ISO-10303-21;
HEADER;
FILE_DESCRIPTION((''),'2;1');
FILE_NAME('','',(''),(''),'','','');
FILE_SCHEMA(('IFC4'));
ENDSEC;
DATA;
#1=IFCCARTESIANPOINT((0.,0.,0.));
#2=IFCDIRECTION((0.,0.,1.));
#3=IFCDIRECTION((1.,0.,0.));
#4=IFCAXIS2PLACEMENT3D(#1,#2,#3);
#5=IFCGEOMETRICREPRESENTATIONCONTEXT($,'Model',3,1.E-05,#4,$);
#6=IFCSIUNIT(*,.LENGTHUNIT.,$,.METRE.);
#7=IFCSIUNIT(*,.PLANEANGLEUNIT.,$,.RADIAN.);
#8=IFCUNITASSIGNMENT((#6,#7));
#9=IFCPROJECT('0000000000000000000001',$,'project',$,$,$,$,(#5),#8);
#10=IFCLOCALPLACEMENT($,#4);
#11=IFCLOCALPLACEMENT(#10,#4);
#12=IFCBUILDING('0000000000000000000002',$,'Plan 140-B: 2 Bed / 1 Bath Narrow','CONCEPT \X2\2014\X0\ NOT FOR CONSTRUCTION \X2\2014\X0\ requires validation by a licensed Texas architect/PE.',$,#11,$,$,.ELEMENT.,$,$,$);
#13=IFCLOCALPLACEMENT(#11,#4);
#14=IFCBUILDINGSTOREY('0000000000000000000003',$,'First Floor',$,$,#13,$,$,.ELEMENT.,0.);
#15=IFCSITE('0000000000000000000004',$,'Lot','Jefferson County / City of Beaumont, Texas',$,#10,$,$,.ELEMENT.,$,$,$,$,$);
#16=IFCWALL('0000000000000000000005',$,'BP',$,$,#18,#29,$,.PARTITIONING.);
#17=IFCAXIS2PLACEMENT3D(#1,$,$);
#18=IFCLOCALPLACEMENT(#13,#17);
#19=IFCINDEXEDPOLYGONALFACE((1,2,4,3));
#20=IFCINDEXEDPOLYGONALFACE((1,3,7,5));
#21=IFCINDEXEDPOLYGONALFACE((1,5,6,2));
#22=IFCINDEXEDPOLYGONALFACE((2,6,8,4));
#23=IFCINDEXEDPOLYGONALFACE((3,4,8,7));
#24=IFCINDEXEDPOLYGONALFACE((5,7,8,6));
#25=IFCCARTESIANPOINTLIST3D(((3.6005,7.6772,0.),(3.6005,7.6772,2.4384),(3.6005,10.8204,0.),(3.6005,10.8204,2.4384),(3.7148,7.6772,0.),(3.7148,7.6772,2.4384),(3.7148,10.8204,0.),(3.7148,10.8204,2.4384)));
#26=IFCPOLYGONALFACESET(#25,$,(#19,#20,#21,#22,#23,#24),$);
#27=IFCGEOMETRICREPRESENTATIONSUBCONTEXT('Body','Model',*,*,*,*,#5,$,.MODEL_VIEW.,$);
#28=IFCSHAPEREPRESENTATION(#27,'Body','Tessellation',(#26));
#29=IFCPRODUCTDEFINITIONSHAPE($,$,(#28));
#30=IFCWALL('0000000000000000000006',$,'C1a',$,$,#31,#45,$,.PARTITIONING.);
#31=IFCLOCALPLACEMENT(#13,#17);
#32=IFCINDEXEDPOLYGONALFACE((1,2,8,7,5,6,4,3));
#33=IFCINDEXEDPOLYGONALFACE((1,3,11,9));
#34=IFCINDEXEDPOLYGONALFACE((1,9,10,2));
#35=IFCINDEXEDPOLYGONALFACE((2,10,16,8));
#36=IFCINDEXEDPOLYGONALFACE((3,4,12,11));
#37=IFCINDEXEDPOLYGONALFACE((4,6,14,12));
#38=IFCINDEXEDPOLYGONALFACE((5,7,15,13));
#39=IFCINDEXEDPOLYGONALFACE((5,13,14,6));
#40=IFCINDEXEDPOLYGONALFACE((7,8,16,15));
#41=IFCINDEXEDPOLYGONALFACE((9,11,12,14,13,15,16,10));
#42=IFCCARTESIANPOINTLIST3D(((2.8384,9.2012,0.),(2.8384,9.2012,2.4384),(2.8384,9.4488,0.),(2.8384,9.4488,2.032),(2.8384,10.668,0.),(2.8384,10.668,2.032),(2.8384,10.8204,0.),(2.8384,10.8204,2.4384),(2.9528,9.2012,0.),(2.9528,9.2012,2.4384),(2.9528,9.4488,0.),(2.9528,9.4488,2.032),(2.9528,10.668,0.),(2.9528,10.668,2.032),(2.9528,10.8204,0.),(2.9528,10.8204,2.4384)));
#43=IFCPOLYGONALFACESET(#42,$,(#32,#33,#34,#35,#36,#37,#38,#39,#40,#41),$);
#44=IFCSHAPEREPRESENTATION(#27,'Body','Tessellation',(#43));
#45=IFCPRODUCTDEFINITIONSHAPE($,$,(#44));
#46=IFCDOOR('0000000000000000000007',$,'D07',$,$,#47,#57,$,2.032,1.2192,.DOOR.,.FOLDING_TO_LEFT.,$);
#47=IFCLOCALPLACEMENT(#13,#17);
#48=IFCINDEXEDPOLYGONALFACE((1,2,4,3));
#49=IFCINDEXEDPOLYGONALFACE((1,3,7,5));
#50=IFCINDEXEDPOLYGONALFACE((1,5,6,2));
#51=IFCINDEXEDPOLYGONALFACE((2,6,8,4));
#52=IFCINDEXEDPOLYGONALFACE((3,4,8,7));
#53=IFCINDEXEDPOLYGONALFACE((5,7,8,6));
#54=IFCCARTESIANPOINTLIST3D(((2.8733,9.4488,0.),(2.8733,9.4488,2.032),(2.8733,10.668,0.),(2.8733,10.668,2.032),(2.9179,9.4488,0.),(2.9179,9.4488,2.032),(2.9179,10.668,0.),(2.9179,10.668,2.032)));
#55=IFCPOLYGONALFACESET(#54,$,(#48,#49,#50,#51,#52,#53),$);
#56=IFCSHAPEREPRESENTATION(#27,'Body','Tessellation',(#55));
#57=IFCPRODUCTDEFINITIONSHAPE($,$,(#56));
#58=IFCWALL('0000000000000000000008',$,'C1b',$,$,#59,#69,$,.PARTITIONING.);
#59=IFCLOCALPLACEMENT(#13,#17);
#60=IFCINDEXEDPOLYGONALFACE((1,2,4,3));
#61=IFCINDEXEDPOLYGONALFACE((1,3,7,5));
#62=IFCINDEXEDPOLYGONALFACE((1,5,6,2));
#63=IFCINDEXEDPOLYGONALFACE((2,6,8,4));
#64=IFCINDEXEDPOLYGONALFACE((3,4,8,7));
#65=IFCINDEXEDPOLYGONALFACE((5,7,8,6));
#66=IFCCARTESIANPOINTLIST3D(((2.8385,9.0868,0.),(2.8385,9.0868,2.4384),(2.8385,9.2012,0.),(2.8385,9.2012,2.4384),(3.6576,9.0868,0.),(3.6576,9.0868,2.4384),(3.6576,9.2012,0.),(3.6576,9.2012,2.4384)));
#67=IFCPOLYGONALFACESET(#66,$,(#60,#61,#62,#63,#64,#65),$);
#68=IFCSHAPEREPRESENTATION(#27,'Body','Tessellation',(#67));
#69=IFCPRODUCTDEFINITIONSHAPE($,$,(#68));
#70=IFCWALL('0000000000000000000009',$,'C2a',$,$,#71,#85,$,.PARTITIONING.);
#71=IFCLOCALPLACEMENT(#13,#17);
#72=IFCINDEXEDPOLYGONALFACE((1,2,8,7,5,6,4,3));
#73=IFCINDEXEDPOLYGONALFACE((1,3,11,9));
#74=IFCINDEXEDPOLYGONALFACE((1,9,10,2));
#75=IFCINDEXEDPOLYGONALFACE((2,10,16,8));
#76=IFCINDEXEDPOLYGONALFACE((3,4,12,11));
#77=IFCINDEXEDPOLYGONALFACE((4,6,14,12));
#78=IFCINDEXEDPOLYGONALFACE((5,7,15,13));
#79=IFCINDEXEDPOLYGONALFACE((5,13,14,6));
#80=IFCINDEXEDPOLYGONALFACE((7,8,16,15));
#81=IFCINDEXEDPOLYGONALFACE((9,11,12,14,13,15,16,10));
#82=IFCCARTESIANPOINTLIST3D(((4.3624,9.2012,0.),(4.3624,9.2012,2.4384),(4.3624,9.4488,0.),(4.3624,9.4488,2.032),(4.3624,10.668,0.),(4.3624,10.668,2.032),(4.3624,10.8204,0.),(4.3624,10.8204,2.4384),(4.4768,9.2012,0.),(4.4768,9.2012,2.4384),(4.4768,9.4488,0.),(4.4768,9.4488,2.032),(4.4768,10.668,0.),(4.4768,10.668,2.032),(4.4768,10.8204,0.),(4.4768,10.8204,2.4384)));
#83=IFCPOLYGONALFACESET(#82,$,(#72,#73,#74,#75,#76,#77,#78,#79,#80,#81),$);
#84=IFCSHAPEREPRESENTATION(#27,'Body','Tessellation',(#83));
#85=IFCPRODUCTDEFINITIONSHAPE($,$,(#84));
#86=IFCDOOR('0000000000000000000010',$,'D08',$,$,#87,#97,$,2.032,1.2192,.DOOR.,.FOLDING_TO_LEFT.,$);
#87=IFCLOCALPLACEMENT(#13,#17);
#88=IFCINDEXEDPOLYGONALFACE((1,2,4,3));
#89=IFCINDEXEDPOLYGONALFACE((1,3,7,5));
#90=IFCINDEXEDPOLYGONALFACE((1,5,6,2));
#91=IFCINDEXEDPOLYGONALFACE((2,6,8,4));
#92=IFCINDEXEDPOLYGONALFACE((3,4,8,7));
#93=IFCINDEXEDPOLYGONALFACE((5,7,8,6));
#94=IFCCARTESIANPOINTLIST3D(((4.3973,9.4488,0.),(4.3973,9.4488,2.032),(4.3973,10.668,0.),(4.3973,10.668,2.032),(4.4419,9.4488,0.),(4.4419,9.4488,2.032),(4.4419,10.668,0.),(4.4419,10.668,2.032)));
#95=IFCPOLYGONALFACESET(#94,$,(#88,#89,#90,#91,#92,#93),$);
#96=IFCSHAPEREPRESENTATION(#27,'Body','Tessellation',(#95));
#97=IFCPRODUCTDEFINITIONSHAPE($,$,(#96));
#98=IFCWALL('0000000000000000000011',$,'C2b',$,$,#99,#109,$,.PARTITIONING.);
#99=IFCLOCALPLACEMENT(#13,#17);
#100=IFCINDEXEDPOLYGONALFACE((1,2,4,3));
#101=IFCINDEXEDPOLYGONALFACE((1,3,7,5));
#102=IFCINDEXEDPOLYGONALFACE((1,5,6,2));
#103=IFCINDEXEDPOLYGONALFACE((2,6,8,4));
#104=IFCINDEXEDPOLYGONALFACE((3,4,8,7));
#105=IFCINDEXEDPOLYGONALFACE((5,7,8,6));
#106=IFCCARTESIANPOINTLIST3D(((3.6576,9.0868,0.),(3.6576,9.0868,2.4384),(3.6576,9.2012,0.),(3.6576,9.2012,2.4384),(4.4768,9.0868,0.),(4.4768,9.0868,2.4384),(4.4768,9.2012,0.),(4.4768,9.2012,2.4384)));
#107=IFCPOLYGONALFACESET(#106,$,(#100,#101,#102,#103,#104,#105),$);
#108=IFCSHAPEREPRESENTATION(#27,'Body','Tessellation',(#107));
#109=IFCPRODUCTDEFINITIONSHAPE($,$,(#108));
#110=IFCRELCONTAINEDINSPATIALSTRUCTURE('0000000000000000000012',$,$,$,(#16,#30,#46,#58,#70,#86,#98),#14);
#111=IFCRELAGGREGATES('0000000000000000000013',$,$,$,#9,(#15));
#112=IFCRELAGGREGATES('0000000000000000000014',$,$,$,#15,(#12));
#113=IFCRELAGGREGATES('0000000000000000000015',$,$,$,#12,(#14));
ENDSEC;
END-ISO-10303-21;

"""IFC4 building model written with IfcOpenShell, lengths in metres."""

from ifc_helpers import new_model, si_unit, frame, frame_2d, origin_with_axes, place, context, subcontext, project, spatial, rectangle, extrude, element, fill, save


model = new_model("IFC4")

# Units and contexts
model_context = context("Model", 3, precision=1e-05, world=origin_with_axes())
body_context = subcontext(model_context, "Body", "Model", "MODEL_VIEW")
ifc_project = project(units=[si_unit("LENGTHUNIT", "METRE"), si_unit("PLANEANGLEUNIT", "RADIAN")], contexts=[model_context])

# Site, building, storey
site_placement = place(None, origin_with_axes())
site = spatial("IfcSite", under=ifc_project, at=site_placement, Name="Lot", Description="Jefferson County / City of Beaumont, Texas", CompositionType="ELEMENT")
building_placement = place(site_placement, origin_with_axes())
building = spatial("IfcBuilding", under=site, at=building_placement, Name="Plan 140-B: 2 Bed / 1 Bath Narrow", Description="CONCEPT — NOT FOR CONSTRUCTION — requires validation by a licensed Texas architect/PE.", CompositionType="ELEMENT")
storey_placement = place(building_placement, origin_with_axes())
storey = spatial("IfcBuildingStorey", under=building, at=storey_placement, Name="First Floor", CompositionType="ELEMENT", Elevation=0.0)

# Wall
wall_1_placement = place(storey_placement, frame((3.6576, 7.6772, 0.0), z_axis=(0.0, 0.0, 1.0), x_axis=(0.0, 1.0, 0.0)))
element("IfcWall", 1, at=wall_1_placement, inside=storey, Name="BP", PredefinedType="PARTITIONING", context=body_context, shape_type="SweptSolid", body=[
    extrude(rectangle(XDim=3.1433, YDim=0.1143, at=frame_2d((1.5716, 0.0), x_axis=(1.0, 0.0))), origin_with_axes(), (0.0, 0.0, 1.0), 2.4384),
])

# Wall, opening, door
wall_2_placement = place(storey_placement, frame((2.8956, 9.2012, 0.0), z_axis=(0.0, 0.0, 1.0), x_axis=(0.0, 1.0, 0.0)))
wall_2 = element("IfcWall", 2, at=wall_2_placement, inside=storey, Name="C1a", PredefinedType="PARTITIONING", context=body_context, shape_type="SweptSolid", body=[
    extrude(rectangle(XDim=1.6193, YDim=0.1143, at=frame_2d((0.8096, 0.0), x_axis=(1.0, 0.0))), origin_with_axes(), (0.0, 0.0, 1.0), 2.4384),
])
opening_1_placement = place(wall_2_placement, frame((0.2477, 0.0, 0.0), z_axis=(0.0, 0.0, 1.0), x_axis=(1.0, 0.0, 0.0)))
opening_1 = element("IfcOpeningElement", 3, at=opening_1_placement, cuts=wall_2, PredefinedType="OPENING", context=body_context, shape_type="SweptSolid", body=[
    extrude(rectangle(XDim=1.2192, YDim=0.1448, at=frame_2d((0.6096, 0.0), x_axis=(1.0, 0.0))), origin_with_axes(), (0.0, 0.0, 1.0), 2.032),
])
door_1_placement = place(opening_1_placement, origin_with_axes())
door_1 = element("IfcDoor", 4, at=door_1_placement, inside=storey, Name="D07", OperationType="FOLDING_TO_LEFT", OverallHeight=2.032, OverallWidth=1.2192, PredefinedType="DOOR", context=body_context, shape_type="SweptSolid", body=[
    extrude(rectangle(XDim=1.2192, YDim=0.0445, at=frame_2d((0.6096, 0.0), x_axis=(1.0, 0.0))), origin_with_axes(), (0.0, 0.0, 1.0), 2.032),
])
fill(opening_1, door_1)

# Wall
wall_3_placement = place(storey_placement, frame((2.8385, 9.144, 0.0), z_axis=(0.0, 0.0, 1.0), x_axis=(1.0, 0.0, 0.0)))
element("IfcWall", 5, at=wall_3_placement, inside=storey, Name="C1b", PredefinedType="PARTITIONING", context=body_context, shape_type="SweptSolid", body=[
    extrude(rectangle(XDim=0.8192, YDim=0.1143, at=frame_2d((0.4096, 0.0), x_axis=(1.0, 0.0))), origin_with_axes(), (0.0, 0.0, 1.0), 2.4384),
])

# Wall, opening, door
wall_4_placement = place(storey_placement, frame((4.4196, 9.2012, 0.0), z_axis=(0.0, 0.0, 1.0), x_axis=(0.0, 1.0, 0.0)))
wall_4 = element("IfcWall", 6, at=wall_4_placement, inside=storey, Name="C2a", PredefinedType="PARTITIONING", context=body_context, shape_type="SweptSolid", body=[
    extrude(rectangle(XDim=1.6193, YDim=0.1143, at=frame_2d((0.8096, 0.0), x_axis=(1.0, 0.0))), origin_with_axes(), (0.0, 0.0, 1.0), 2.4384),
])
opening_2_placement = place(wall_4_placement, frame((0.2477, 0.0, 0.0), z_axis=(0.0, 0.0, 1.0), x_axis=(1.0, 0.0, 0.0)))
opening_2 = element("IfcOpeningElement", 7, at=opening_2_placement, cuts=wall_4, PredefinedType="OPENING", context=body_context, shape_type="SweptSolid", body=[
    extrude(rectangle(XDim=1.2192, YDim=0.1448, at=frame_2d((0.6096, 0.0), x_axis=(1.0, 0.0))), origin_with_axes(), (0.0, 0.0, 1.0), 2.032),
])
door_2_placement = place(opening_2_placement, origin_with_axes())
door_2 = element("IfcDoor", 8, at=door_2_placement, inside=storey, Name="D08", OperationType="FOLDING_TO_LEFT", OverallHeight=2.032, OverallWidth=1.2192, PredefinedType="DOOR", context=body_context, shape_type="SweptSolid", body=[
    extrude(rectangle(XDim=1.2192, YDim=0.0445, at=frame_2d((0.6096, 0.0), x_axis=(1.0, 0.0))), origin_with_axes(), (0.0, 0.0, 1.0), 2.032),
])
fill(opening_2, door_2)

# Wall
wall_5_placement = place(storey_placement, frame((3.6576, 9.144, 0.0), z_axis=(0.0, 0.0, 1.0), x_axis=(1.0, 0.0, 0.0)))
element("IfcWall", 9, at=wall_5_placement, inside=storey, Name="C2b", PredefinedType="PARTITIONING", context=body_context, shape_type="SweptSolid", body=[
    extrude(rectangle(XDim=0.8192, YDim=0.1143, at=frame_2d((0.4096, 0.0), x_axis=(1.0, 0.0))), origin_with_axes(), (0.0, 0.0, 1.0), 2.4384),
])

save(model, "model.ifc")
